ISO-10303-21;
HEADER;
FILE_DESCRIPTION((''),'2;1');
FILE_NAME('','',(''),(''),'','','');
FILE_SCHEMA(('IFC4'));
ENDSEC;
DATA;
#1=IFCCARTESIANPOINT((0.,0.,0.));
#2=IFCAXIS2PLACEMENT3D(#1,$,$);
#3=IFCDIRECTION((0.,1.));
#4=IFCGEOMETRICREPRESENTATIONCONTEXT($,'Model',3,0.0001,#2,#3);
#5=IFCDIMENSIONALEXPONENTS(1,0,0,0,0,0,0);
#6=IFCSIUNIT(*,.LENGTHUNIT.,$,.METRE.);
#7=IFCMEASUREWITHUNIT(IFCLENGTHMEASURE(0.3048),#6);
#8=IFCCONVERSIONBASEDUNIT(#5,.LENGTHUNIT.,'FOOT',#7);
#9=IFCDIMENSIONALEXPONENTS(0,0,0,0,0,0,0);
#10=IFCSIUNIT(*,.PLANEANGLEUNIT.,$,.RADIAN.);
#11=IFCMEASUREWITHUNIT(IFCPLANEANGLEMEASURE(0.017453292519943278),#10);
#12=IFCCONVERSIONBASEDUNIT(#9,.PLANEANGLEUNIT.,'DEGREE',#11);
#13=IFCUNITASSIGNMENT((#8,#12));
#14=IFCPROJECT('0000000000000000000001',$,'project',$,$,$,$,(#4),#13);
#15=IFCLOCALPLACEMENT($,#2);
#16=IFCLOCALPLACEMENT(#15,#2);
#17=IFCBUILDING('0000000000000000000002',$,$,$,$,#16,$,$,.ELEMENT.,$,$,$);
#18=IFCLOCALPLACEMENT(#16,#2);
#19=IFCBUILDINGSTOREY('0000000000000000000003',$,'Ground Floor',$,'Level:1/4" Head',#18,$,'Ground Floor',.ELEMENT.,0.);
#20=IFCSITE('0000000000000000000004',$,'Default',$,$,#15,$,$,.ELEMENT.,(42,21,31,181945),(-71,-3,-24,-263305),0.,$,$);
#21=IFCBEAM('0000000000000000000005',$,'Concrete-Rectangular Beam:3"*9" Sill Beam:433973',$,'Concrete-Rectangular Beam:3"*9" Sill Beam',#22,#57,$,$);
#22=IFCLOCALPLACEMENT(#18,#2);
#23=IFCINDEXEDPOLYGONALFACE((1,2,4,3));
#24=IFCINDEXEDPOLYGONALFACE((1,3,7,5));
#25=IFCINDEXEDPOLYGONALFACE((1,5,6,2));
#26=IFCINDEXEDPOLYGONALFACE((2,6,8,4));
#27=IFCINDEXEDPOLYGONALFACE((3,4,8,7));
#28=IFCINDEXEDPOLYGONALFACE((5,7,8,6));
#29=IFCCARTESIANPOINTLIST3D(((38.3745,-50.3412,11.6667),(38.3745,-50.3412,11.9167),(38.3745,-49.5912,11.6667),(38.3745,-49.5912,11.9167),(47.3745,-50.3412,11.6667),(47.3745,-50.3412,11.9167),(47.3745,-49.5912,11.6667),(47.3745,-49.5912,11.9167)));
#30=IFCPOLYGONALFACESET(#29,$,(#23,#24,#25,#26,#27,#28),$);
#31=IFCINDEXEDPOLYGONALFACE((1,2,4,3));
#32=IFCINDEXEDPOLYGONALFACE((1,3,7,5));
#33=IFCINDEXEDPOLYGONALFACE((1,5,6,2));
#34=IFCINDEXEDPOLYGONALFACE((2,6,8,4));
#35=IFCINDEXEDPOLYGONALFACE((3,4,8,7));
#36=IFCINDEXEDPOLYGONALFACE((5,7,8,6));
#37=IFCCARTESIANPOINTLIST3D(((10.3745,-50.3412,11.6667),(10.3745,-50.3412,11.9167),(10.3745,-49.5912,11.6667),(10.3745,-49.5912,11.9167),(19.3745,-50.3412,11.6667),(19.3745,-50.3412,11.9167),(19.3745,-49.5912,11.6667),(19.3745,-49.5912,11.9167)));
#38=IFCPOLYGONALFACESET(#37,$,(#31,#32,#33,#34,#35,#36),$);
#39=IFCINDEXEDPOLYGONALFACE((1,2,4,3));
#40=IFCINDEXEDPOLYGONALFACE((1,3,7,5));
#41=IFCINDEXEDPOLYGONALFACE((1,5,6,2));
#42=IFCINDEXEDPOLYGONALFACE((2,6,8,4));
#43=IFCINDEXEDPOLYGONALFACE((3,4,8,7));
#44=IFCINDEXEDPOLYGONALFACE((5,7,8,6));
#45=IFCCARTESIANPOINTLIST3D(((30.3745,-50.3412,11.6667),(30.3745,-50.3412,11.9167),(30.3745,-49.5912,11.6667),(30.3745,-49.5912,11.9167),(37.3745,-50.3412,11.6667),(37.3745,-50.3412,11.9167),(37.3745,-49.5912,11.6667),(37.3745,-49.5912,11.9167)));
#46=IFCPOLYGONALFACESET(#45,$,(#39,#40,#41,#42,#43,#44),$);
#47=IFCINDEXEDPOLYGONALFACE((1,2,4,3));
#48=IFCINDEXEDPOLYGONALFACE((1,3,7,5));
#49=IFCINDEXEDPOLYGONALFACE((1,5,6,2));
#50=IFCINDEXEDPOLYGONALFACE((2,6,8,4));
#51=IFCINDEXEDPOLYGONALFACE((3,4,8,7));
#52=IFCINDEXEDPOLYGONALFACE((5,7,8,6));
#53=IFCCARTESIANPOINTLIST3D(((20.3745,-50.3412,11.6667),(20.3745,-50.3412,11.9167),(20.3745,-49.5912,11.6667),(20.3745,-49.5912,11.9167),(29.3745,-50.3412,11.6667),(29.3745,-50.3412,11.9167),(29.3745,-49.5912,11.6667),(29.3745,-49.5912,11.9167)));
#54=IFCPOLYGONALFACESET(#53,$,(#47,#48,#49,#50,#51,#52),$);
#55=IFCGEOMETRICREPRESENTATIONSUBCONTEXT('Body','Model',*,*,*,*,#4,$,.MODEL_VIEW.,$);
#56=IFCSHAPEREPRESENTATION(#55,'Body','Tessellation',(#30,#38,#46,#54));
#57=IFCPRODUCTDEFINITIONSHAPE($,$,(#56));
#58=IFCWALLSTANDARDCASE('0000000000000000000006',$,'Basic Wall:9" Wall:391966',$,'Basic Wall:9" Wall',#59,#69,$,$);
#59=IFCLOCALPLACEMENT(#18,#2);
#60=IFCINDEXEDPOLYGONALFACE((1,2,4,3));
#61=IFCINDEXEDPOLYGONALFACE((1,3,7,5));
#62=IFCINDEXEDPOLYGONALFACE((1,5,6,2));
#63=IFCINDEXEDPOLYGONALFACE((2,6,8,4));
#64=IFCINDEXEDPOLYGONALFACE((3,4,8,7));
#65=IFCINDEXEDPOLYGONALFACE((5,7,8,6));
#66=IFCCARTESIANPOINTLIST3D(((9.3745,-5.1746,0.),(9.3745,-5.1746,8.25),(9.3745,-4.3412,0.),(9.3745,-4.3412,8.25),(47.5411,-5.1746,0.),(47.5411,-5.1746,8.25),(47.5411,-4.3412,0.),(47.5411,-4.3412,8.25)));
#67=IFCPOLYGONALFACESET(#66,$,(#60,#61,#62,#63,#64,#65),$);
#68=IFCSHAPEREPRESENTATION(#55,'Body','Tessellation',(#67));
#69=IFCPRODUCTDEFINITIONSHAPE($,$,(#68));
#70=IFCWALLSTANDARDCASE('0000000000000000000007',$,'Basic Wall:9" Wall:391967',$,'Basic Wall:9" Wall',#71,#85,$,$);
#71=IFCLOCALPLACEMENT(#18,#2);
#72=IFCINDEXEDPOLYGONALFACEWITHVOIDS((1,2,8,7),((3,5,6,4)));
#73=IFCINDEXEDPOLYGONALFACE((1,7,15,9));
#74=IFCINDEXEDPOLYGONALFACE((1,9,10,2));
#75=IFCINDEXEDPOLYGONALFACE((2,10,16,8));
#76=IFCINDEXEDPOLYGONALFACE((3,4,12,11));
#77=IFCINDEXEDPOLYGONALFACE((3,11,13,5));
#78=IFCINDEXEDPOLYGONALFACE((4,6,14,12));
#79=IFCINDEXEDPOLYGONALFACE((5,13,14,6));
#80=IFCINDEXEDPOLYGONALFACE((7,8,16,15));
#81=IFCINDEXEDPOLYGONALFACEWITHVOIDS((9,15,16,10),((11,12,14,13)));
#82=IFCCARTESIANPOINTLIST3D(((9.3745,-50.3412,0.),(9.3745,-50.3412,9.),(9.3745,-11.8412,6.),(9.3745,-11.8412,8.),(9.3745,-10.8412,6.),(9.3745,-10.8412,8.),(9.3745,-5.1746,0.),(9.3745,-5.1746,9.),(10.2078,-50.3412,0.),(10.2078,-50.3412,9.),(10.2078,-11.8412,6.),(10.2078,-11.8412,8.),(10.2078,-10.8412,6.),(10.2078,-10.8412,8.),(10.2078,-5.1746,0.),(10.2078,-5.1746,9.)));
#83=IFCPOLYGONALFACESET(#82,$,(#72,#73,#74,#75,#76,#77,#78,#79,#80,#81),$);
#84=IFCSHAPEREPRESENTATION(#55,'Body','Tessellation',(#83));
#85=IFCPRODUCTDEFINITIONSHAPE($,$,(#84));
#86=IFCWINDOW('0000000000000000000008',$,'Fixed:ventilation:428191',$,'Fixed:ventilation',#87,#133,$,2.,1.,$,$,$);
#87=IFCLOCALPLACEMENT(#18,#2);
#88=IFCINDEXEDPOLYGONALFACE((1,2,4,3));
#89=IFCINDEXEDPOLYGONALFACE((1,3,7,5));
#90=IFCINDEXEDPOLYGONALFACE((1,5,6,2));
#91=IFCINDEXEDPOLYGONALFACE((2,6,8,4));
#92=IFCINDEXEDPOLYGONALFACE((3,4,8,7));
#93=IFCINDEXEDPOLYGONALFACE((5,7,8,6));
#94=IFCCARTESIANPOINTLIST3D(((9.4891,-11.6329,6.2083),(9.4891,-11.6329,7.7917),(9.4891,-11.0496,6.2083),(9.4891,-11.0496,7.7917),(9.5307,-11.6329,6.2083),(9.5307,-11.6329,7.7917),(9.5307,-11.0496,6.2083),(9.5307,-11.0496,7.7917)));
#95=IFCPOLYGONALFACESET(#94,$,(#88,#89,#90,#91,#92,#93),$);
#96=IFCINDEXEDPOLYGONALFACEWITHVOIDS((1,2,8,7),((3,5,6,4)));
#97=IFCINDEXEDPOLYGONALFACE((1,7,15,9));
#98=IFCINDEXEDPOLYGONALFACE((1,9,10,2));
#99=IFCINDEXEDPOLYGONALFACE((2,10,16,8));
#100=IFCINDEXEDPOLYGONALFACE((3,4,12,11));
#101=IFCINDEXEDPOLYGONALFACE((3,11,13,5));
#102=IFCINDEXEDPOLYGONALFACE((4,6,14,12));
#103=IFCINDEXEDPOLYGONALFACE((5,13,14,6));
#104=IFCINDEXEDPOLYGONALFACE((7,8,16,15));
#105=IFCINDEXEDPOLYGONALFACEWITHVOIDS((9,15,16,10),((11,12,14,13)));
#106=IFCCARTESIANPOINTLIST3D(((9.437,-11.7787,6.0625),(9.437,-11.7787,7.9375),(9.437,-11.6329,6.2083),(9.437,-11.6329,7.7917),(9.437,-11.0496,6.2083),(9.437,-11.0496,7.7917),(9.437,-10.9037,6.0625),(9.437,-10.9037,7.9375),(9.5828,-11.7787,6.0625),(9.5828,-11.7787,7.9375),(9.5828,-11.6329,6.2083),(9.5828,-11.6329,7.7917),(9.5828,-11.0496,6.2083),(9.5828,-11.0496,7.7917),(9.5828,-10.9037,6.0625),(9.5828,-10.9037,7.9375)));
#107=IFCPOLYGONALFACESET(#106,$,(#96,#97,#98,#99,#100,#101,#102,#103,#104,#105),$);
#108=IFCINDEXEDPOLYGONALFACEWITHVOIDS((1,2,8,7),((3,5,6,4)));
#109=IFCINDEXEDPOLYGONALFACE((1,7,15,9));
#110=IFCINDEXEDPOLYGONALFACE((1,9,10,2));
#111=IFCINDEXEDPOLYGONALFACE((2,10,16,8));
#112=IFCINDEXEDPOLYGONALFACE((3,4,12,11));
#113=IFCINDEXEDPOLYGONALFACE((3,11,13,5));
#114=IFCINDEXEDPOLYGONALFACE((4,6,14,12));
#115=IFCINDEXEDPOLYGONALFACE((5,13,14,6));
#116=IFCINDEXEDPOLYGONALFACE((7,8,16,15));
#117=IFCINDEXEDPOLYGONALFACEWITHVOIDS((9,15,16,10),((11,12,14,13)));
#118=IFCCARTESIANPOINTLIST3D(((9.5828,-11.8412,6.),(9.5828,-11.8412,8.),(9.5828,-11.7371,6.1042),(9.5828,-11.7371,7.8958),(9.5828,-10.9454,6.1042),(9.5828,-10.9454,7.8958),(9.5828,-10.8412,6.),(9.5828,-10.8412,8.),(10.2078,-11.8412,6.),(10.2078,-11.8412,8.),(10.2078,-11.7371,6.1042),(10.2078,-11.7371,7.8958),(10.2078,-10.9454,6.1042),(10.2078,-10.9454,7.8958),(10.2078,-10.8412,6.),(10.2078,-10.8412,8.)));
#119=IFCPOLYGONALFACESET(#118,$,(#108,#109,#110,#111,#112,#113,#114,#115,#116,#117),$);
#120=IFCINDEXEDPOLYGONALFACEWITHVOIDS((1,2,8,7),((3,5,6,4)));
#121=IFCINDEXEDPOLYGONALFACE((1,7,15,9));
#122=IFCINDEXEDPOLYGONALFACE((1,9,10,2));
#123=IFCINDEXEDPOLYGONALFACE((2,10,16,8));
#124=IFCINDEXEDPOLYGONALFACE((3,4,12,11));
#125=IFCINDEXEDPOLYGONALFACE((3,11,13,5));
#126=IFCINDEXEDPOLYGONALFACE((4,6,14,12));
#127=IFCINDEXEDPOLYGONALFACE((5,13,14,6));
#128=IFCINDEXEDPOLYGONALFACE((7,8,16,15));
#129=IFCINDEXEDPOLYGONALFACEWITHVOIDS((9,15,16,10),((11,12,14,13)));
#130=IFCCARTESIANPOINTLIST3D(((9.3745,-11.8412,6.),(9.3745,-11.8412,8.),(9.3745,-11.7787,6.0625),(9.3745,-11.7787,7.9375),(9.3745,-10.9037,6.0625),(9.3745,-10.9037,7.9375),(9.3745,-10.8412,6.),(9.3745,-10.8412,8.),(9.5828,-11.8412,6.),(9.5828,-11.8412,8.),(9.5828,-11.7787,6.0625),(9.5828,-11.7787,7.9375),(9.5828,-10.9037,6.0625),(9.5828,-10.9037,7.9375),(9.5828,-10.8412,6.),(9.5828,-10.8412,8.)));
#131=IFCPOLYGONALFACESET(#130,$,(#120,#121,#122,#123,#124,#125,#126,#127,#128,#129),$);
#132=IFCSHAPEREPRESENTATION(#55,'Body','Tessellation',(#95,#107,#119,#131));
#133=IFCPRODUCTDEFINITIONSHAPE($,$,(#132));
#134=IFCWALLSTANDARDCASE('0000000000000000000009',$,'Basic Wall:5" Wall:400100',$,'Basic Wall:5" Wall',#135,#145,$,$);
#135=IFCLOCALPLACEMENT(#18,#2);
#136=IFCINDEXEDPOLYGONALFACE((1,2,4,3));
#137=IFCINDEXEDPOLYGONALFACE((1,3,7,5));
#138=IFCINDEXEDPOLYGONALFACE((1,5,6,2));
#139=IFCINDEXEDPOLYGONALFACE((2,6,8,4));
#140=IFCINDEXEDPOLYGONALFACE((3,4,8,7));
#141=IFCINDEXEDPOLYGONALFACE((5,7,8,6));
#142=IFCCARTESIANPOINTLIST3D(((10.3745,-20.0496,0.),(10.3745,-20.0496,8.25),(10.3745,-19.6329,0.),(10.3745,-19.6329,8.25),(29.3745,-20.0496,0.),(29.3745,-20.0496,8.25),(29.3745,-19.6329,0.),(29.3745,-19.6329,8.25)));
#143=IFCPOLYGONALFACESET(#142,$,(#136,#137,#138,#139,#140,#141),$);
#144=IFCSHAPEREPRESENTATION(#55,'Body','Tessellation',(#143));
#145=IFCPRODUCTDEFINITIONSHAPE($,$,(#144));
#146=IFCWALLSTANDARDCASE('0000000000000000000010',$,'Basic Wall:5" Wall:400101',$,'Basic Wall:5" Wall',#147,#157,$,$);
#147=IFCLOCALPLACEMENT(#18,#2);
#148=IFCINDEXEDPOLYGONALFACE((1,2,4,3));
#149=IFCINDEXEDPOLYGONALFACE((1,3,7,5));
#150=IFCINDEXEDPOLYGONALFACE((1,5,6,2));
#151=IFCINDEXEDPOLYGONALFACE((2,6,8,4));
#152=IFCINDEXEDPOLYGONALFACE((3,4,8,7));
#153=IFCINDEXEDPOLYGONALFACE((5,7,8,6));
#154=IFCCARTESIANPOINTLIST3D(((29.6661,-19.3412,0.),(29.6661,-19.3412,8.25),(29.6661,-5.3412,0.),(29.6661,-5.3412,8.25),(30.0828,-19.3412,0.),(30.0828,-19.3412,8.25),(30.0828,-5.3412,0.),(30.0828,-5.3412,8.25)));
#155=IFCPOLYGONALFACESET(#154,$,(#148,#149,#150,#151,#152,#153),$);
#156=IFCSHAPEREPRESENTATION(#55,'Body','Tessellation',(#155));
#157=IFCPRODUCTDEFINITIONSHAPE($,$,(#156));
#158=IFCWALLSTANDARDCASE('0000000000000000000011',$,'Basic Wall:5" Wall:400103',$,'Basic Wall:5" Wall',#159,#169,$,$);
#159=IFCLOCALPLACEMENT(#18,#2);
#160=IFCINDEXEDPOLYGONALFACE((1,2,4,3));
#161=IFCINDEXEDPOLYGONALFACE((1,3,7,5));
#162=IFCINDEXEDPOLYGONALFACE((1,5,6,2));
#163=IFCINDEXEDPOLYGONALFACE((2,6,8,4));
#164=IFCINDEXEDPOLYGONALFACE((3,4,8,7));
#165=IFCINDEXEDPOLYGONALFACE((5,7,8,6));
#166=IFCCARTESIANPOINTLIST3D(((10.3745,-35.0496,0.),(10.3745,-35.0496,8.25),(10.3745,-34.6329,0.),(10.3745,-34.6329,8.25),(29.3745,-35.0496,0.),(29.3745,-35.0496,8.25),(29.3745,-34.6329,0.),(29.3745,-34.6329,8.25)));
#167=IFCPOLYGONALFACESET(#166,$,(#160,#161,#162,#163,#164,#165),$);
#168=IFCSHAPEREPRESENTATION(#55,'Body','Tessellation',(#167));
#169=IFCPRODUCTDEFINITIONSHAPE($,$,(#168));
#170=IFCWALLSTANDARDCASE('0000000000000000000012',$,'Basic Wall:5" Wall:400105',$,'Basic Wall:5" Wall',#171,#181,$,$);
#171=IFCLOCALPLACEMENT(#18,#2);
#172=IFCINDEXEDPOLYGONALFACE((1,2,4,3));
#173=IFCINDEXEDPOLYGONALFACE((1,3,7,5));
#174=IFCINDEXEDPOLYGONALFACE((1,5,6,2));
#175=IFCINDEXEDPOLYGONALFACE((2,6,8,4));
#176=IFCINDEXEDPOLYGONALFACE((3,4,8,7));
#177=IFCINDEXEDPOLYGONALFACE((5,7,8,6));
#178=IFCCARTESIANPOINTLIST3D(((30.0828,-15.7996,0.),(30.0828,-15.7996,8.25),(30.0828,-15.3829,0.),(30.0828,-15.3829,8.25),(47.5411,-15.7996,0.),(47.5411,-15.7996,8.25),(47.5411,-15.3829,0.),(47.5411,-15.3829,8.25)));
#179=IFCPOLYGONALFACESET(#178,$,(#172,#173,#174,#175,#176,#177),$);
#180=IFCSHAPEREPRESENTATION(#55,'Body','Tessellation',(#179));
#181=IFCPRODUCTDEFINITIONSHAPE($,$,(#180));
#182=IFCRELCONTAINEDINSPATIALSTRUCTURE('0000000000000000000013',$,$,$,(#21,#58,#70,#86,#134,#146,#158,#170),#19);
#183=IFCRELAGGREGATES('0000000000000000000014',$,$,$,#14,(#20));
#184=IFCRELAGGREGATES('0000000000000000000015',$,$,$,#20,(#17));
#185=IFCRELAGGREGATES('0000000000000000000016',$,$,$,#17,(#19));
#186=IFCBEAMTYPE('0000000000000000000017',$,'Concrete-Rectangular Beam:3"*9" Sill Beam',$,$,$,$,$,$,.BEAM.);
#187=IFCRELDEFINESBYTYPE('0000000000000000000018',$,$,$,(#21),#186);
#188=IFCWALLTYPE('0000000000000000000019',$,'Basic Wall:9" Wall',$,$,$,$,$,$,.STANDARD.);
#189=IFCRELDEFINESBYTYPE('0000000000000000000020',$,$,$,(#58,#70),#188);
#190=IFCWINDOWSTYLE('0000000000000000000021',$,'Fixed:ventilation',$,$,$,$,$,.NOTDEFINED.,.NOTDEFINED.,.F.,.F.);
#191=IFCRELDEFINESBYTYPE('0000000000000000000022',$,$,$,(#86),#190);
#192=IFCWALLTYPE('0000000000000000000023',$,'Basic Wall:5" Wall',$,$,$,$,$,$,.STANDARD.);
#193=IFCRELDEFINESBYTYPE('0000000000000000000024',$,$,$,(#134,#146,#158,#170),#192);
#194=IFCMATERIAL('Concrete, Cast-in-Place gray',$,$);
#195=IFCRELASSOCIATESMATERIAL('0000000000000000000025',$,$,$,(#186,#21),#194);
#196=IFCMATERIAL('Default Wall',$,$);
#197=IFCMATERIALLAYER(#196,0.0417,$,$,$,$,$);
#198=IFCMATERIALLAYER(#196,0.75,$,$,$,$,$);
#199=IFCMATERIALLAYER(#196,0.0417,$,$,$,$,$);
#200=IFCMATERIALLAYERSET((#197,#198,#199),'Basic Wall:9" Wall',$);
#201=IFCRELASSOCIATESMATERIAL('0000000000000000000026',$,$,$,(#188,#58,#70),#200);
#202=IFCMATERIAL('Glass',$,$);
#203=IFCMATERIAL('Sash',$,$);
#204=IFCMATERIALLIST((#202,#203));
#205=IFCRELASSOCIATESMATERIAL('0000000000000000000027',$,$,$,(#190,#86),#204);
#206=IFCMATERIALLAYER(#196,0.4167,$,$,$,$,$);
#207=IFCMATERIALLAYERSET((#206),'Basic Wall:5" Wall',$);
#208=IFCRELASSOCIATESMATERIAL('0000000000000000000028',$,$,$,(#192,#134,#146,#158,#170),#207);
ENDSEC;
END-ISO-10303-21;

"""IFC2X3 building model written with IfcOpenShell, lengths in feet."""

from ifc_helpers import new_model, entity, si_unit, converted_unit, direction, frame, frame_2d, origin, origin_2d_with_axis, place, context, subcontext, project, spatial, polyline, rectangle, outline, extrude, clip, bounded_halfspace, source, transform, mapped, material, material_list, layer, layer_set, layer_usage, type_object, type_shapes, element, fill, save


model = new_model("IFC2X3")

# Units and contexts
model_context = context("Model", 3, precision=0.0001, world=origin(), true_north=direction((0.0, 1.0)))
body_context = subcontext(model_context, "Body", "Model", "MODEL_VIEW")
ifc_project = project(units=[converted_unit("LENGTHUNIT", "FOOT", entity("IfcLengthMeasure", 0.3048), si_unit("LENGTHUNIT", "METRE"), dimensions=[1, 0, 0, 0, 0, 0, 0]), converted_unit("PLANEANGLEUNIT", "DEGREE", entity("IfcPlaneAngleMeasure", 0.017453292519943278), si_unit("PLANEANGLEUNIT", "RADIAN"), dimensions=[0, 0, 0, 0, 0, 0, 0])], contexts=[model_context])

# Site, building, storey
site_placement = place(None, origin())
site = spatial("IfcSite", under=ifc_project, at=site_placement, Name="Default", CompositionType="ELEMENT", RefLatitude=(42, 21, 31, 181945), RefLongitude=(-71, -3, -24, -263305), RefElevation=0.0)
building_placement = place(site_placement, origin())
building = spatial("IfcBuilding", under=site, at=building_placement, CompositionType="ELEMENT")
storey_placement = place(building_placement, origin())
storey = spatial("IfcBuildingStorey", under=building, at=storey_placement, Name="Ground Floor", ObjectType="Level:1/4\" Head", LongName="Ground Floor", CompositionType="ELEMENT", Elevation=0.0)

# Shared definitions
ifc_material_1 = material(Name="Concrete, Cast-in-Place gray")

# Beam
beam_type_1 = type_object("IfcBeamType", Name="Concrete-Rectangular Beam:3\"*9\" Sill Beam", PredefinedType="BEAM", material=ifc_material_1)
shared_shape_1 = source(origin(), body_context, "Body", "SweptSolid", [
    extrude(rectangle(XDim=0.25, YDim=0.75, at=frame_2d((0.0, 0.0), x_axis=(1.0, 0.0))), frame((38.3745, -49.9662, 11.7917), z_axis=(1.0, 0.0, 0.0), x_axis=(0.0, 0.0, -1.0)), (0.0, 0.0, 1.0), 9.0),
    extrude(rectangle(XDim=0.25, YDim=0.75, at=frame_2d((0.0, 0.0), x_axis=(1.0, 0.0))), frame((10.3745, -49.9662, 11.7917), z_axis=(1.0, 0.0, 0.0), x_axis=(0.0, 0.0, -1.0)), (0.0, 0.0, 1.0), 9.0),
    extrude(rectangle(XDim=0.25, YDim=0.75, at=origin_2d_with_axis()), frame((30.3745, -49.9662, 11.7917), z_axis=(1.0, 0.0, 0.0), x_axis=(0.0, 0.0, -1.0)), (0.0, 0.0, 1.0), 7.0),
    extrude(rectangle(XDim=0.25, YDim=0.75, at=origin_2d_with_axis()), frame((20.3745, -49.9662, 11.7917), z_axis=(1.0, 0.0, 0.0), x_axis=(0.0, 0.0, -1.0)), (0.0, 0.0, 1.0), 9.0),
])
type_shapes(beam_type_1, [shared_shape_1])
beam_1_placement = place(storey_placement, origin())
element("IfcBeam", 1, at=beam_1_placement, inside=storey, type_object=beam_type_1, material=ifc_material_1, Name="Concrete-Rectangular Beam:3\"*9\" Sill Beam:433973", ObjectType="Concrete-Rectangular Beam:3\"*9\" Sill Beam", context=body_context, shape_type="MappedRepresentation", body=[
    mapped(shared_shape_1, transform((0.0, 0.0, 0.0), scale=1.0)),
])

# Wall
ifc_material_2 = material(Name="Default Wall")
ifc_layer_1 = layer(ifc_material_2, 0.0417)
ifc_layer_2 = layer(ifc_material_2, 0.75)
ifc_layer_3 = layer(ifc_material_2, 0.0417)
ifc_layer_set_1 = layer_set([ifc_layer_1, ifc_layer_2, ifc_layer_3], Name="Basic Wall:9\" Wall")
ifc_layer_usage_1 = layer_usage(ifc_layer_set_1, "AXIS2", "NEGATIVE", 0.4167)
wall_type_1 = type_object("IfcWallType", Name="Basic Wall:9\" Wall", PredefinedType="STANDARD", material=ifc_layer_set_1)
wall_1_placement = place(storey_placement, frame((9.3745, -4.7579, 0.0)))
element("IfcWallStandardCase", 2, at=wall_1_placement, inside=storey, type_object=wall_type_1, material=ifc_layer_usage_1, Name="Basic Wall:9\" Wall:391966", ObjectType="Basic Wall:9\" Wall", context=body_context, shape_type="SweptSolid", body=[
    extrude(rectangle(XDim=38.1667, YDim=0.8333, at=frame_2d((19.0833, 0.0), x_axis=(-1.0, 0.0))), origin(), (0.0, 0.0, 1.0), 8.25),
])

# Wall, opening, window
wall_2_placement = place(storey_placement, frame((9.7911, -50.3412, 0.0), z_axis=(0.0, 0.0, 1.0), x_axis=(0.0, 1.0, 0.0)))
wall_2 = element("IfcWallStandardCase", 3, at=wall_2_placement, inside=storey, type_object=wall_type_1, material=ifc_layer_usage_1, Name="Basic Wall:9\" Wall:391967", ObjectType="Basic Wall:9\" Wall", context=body_context, shape_type="Clipping", body=[
    clip(extrude(rectangle(XDim=45.1667, YDim=0.8333, at=frame_2d((22.5833, 0.0), x_axis=(-1.0, 0.0))), origin(), (0.0, 0.0, 1.0), 9.0), bounded_halfspace(frame((0.0, -0.4167, 9.0), z_axis=(0.0, 0.0, -1.0), x_axis=(-1.0, 0.0, 0.0)), True, frame((0.0, -0.4167, 9.0)), polyline([(0.0, 0.0), (0.8333, 0.0), (45.1667, 0.0), (45.1667, 0.8333), (0.0, 0.8333), (0.0, 0.0)]))),
])
opening_1_placement = place(wall_2_placement, frame((38.5, -0.4167, 6.0)))
opening_1 = element("IfcOpeningElement", 4, at=opening_1_placement, cuts=wall_2, ObjectType="Opening", context=body_context, shape_type="SweptSolid", body=[
    extrude(rectangle(XDim=2.0, YDim=1.0, at=frame_2d((1.0, 0.5), x_axis=(-1.0, 0.0))), frame((0.0, 0.0, 0.0), z_axis=(0.0, 1.0, 0.0), x_axis=(0.0, 0.0, 1.0)), (0.0, 0.0, 1.0), 0.8333),
])
ifc_material_3 = material(Name="Glass")
ifc_material_4 = material(Name="Sash")
ifc_material_list_1 = material_list([ifc_material_3, ifc_material_4])
window_style = type_object("IfcWindowStyle", Name="Fixed:ventilation", ConstructionType="NOTDEFINED", OperationType="NOTDEFINED", ParameterTakesPrecedence=False, Sizeable=False, material=ifc_material_list_1)
shared_shape_2 = source(origin(), body_context, "Body", "SweptSolid", [
    extrude(rectangle(XDim=0.0417, YDim=0.5833, at=origin_2d_with_axis()), frame((0.5, 0.6979, 0.2083), z_axis=(0.0, 0.0, 1.0), x_axis=(0.0, 1.0, 0.0)), (0.0, 0.0, 1.0), 1.5833),
    extrude(outline(polyline([(-0.4375, -0.9375), (0.4375, -0.9375), (0.4375, 0.9375), (-0.4375, 0.9375), (-0.4375, -0.9375)]), holes=[polyline([(-0.2917, -0.7917), (-0.2917, 0.7917), (0.2917, 0.7917), (0.2917, -0.7917), (-0.2917, -0.7917)])]), frame((0.5, 0.625, 1.0), z_axis=(0.0, 1.0, 0.0), x_axis=(1.0, 0.0, 0.0)), (0.0, 0.0, 1.0), 0.1458),
    extrude(outline(polyline([(-0.5, -1.0), (0.5, -1.0), (0.5, 1.0), (-0.5, 1.0), (-0.5, -1.0)]), holes=[polyline([(-0.3958, -0.8958), (-0.3958, 0.8958), (0.3958, 0.8958), (0.3958, -0.8958), (-0.3958, -0.8958)])]), frame((0.5, 0.0, 1.0), z_axis=(0.0, 1.0, 0.0), x_axis=(1.0, 0.0, 0.0)), (0.0, 0.0, 1.0), 0.625),
    extrude(outline(polyline([(-1.0, -0.5), (1.0, -0.5), (1.0, 0.5), (-1.0, 0.5), (-1.0, -0.5)]), holes=[polyline([(-0.9375, -0.4375), (-0.9375, 0.4375), (0.9375, 0.4375), (0.9375, -0.4375), (-0.9375, -0.4375)])]), frame((0.5, 0.625, 1.0), z_axis=(0.0, 1.0, 0.0), x_axis=(0.0, 0.0, -1.0)), (0.0, 0.0, 1.0), 0.2083),
])
type_shapes(window_style, [shared_shape_2])
window_placement = place(opening_1_placement, origin())
window = element("IfcWindow", 5, at=window_placement, inside=storey, type_object=window_style, material=ifc_material_list_1, Name="Fixed:ventilation:428191", ObjectType="Fixed:ventilation", OverallHeight=2.0, OverallWidth=1.0, context=body_context, shape_type="MappedRepresentation", body=[
    mapped(shared_shape_2, transform((0.0, 0.0, 0.0), scale=1.0)),
])
fill(opening_1, window)

# Walls
ifc_layer_4 = layer(ifc_material_2, 0.4167)
ifc_layer_set_2 = layer_set([ifc_layer_4], Name="Basic Wall:5\" Wall")
ifc_layer_usage_2 = layer_usage(ifc_layer_set_2, "AXIS2", "NEGATIVE", 0.2083)
wall_type_2 = type_object("IfcWallType", Name="Basic Wall:5\" Wall", PredefinedType="STANDARD", material=ifc_layer_set_2)
wall_3_placement = place(storey_placement, frame((10.3745, -19.8412, 0.0)))
element("IfcWallStandardCase", 6, at=wall_3_placement, inside=storey, type_object=wall_type_2, material=ifc_layer_usage_2, Name="Basic Wall:5\" Wall:400100", ObjectType="Basic Wall:5\" Wall", context=body_context, shape_type="SweptSolid", body=[
    extrude(rectangle(XDim=19.0, YDim=0.4167, at=frame_2d((9.5, 0.0), x_axis=(-1.0, 0.0))), origin(), (0.0, 0.0, 1.0), 8.25),
])
wall_4_placement = place(storey_placement, frame((29.8745, -19.3412, 0.0), z_axis=(0.0, 0.0, 1.0), x_axis=(0.0, 1.0, 0.0)))
element("IfcWallStandardCase", 7, at=wall_4_placement, inside=storey, type_object=wall_type_2, material=ifc_layer_usage_2, Name="Basic Wall:5\" Wall:400101", ObjectType="Basic Wall:5\" Wall", context=body_context, shape_type="SweptSolid", body=[
    extrude(rectangle(XDim=14.0, YDim=0.4167, at=frame_2d((7.0, 0.0), x_axis=(-1.0, 0.0))), origin(), (0.0, 0.0, 1.0), 8.25),
])

# Wall
wall_5_placement = place(storey_placement, frame((29.3745, -34.8412, 0.0), z_axis=(0.0, 0.0, 1.0), x_axis=(-1.0, 0.0, 0.0)))
element("IfcWallStandardCase", 8, at=wall_5_placement, inside=storey, type_object=wall_type_2, material=ifc_layer_usage_2, Name="Basic Wall:5\" Wall:400103", ObjectType="Basic Wall:5\" Wall", context=body_context, shape_type="SweptSolid", body=[
    extrude(rectangle(XDim=19.0, YDim=0.4167, at=frame_2d((9.5, 0.0), x_axis=(-1.0, 0.0))), origin(), (0.0, 0.0, 1.0), 8.25),
])

# Wall
wall_6_placement = place(storey_placement, frame((30.0828, -15.5912, 0.0)))
element("IfcWallStandardCase", 9, at=wall_6_placement, inside=storey, type_object=wall_type_2, material=ifc_layer_usage_2, Name="Basic Wall:5\" Wall:400105", ObjectType="Basic Wall:5\" Wall", context=body_context, shape_type="SweptSolid", body=[
    extrude(rectangle(XDim=17.4583, YDim=0.4167, at=frame_2d((8.7292, 0.0), x_axis=(-1.0, 0.0))), origin(), (0.0, 0.0, 1.0), 8.25),
])

save(model, "model.ifc")
